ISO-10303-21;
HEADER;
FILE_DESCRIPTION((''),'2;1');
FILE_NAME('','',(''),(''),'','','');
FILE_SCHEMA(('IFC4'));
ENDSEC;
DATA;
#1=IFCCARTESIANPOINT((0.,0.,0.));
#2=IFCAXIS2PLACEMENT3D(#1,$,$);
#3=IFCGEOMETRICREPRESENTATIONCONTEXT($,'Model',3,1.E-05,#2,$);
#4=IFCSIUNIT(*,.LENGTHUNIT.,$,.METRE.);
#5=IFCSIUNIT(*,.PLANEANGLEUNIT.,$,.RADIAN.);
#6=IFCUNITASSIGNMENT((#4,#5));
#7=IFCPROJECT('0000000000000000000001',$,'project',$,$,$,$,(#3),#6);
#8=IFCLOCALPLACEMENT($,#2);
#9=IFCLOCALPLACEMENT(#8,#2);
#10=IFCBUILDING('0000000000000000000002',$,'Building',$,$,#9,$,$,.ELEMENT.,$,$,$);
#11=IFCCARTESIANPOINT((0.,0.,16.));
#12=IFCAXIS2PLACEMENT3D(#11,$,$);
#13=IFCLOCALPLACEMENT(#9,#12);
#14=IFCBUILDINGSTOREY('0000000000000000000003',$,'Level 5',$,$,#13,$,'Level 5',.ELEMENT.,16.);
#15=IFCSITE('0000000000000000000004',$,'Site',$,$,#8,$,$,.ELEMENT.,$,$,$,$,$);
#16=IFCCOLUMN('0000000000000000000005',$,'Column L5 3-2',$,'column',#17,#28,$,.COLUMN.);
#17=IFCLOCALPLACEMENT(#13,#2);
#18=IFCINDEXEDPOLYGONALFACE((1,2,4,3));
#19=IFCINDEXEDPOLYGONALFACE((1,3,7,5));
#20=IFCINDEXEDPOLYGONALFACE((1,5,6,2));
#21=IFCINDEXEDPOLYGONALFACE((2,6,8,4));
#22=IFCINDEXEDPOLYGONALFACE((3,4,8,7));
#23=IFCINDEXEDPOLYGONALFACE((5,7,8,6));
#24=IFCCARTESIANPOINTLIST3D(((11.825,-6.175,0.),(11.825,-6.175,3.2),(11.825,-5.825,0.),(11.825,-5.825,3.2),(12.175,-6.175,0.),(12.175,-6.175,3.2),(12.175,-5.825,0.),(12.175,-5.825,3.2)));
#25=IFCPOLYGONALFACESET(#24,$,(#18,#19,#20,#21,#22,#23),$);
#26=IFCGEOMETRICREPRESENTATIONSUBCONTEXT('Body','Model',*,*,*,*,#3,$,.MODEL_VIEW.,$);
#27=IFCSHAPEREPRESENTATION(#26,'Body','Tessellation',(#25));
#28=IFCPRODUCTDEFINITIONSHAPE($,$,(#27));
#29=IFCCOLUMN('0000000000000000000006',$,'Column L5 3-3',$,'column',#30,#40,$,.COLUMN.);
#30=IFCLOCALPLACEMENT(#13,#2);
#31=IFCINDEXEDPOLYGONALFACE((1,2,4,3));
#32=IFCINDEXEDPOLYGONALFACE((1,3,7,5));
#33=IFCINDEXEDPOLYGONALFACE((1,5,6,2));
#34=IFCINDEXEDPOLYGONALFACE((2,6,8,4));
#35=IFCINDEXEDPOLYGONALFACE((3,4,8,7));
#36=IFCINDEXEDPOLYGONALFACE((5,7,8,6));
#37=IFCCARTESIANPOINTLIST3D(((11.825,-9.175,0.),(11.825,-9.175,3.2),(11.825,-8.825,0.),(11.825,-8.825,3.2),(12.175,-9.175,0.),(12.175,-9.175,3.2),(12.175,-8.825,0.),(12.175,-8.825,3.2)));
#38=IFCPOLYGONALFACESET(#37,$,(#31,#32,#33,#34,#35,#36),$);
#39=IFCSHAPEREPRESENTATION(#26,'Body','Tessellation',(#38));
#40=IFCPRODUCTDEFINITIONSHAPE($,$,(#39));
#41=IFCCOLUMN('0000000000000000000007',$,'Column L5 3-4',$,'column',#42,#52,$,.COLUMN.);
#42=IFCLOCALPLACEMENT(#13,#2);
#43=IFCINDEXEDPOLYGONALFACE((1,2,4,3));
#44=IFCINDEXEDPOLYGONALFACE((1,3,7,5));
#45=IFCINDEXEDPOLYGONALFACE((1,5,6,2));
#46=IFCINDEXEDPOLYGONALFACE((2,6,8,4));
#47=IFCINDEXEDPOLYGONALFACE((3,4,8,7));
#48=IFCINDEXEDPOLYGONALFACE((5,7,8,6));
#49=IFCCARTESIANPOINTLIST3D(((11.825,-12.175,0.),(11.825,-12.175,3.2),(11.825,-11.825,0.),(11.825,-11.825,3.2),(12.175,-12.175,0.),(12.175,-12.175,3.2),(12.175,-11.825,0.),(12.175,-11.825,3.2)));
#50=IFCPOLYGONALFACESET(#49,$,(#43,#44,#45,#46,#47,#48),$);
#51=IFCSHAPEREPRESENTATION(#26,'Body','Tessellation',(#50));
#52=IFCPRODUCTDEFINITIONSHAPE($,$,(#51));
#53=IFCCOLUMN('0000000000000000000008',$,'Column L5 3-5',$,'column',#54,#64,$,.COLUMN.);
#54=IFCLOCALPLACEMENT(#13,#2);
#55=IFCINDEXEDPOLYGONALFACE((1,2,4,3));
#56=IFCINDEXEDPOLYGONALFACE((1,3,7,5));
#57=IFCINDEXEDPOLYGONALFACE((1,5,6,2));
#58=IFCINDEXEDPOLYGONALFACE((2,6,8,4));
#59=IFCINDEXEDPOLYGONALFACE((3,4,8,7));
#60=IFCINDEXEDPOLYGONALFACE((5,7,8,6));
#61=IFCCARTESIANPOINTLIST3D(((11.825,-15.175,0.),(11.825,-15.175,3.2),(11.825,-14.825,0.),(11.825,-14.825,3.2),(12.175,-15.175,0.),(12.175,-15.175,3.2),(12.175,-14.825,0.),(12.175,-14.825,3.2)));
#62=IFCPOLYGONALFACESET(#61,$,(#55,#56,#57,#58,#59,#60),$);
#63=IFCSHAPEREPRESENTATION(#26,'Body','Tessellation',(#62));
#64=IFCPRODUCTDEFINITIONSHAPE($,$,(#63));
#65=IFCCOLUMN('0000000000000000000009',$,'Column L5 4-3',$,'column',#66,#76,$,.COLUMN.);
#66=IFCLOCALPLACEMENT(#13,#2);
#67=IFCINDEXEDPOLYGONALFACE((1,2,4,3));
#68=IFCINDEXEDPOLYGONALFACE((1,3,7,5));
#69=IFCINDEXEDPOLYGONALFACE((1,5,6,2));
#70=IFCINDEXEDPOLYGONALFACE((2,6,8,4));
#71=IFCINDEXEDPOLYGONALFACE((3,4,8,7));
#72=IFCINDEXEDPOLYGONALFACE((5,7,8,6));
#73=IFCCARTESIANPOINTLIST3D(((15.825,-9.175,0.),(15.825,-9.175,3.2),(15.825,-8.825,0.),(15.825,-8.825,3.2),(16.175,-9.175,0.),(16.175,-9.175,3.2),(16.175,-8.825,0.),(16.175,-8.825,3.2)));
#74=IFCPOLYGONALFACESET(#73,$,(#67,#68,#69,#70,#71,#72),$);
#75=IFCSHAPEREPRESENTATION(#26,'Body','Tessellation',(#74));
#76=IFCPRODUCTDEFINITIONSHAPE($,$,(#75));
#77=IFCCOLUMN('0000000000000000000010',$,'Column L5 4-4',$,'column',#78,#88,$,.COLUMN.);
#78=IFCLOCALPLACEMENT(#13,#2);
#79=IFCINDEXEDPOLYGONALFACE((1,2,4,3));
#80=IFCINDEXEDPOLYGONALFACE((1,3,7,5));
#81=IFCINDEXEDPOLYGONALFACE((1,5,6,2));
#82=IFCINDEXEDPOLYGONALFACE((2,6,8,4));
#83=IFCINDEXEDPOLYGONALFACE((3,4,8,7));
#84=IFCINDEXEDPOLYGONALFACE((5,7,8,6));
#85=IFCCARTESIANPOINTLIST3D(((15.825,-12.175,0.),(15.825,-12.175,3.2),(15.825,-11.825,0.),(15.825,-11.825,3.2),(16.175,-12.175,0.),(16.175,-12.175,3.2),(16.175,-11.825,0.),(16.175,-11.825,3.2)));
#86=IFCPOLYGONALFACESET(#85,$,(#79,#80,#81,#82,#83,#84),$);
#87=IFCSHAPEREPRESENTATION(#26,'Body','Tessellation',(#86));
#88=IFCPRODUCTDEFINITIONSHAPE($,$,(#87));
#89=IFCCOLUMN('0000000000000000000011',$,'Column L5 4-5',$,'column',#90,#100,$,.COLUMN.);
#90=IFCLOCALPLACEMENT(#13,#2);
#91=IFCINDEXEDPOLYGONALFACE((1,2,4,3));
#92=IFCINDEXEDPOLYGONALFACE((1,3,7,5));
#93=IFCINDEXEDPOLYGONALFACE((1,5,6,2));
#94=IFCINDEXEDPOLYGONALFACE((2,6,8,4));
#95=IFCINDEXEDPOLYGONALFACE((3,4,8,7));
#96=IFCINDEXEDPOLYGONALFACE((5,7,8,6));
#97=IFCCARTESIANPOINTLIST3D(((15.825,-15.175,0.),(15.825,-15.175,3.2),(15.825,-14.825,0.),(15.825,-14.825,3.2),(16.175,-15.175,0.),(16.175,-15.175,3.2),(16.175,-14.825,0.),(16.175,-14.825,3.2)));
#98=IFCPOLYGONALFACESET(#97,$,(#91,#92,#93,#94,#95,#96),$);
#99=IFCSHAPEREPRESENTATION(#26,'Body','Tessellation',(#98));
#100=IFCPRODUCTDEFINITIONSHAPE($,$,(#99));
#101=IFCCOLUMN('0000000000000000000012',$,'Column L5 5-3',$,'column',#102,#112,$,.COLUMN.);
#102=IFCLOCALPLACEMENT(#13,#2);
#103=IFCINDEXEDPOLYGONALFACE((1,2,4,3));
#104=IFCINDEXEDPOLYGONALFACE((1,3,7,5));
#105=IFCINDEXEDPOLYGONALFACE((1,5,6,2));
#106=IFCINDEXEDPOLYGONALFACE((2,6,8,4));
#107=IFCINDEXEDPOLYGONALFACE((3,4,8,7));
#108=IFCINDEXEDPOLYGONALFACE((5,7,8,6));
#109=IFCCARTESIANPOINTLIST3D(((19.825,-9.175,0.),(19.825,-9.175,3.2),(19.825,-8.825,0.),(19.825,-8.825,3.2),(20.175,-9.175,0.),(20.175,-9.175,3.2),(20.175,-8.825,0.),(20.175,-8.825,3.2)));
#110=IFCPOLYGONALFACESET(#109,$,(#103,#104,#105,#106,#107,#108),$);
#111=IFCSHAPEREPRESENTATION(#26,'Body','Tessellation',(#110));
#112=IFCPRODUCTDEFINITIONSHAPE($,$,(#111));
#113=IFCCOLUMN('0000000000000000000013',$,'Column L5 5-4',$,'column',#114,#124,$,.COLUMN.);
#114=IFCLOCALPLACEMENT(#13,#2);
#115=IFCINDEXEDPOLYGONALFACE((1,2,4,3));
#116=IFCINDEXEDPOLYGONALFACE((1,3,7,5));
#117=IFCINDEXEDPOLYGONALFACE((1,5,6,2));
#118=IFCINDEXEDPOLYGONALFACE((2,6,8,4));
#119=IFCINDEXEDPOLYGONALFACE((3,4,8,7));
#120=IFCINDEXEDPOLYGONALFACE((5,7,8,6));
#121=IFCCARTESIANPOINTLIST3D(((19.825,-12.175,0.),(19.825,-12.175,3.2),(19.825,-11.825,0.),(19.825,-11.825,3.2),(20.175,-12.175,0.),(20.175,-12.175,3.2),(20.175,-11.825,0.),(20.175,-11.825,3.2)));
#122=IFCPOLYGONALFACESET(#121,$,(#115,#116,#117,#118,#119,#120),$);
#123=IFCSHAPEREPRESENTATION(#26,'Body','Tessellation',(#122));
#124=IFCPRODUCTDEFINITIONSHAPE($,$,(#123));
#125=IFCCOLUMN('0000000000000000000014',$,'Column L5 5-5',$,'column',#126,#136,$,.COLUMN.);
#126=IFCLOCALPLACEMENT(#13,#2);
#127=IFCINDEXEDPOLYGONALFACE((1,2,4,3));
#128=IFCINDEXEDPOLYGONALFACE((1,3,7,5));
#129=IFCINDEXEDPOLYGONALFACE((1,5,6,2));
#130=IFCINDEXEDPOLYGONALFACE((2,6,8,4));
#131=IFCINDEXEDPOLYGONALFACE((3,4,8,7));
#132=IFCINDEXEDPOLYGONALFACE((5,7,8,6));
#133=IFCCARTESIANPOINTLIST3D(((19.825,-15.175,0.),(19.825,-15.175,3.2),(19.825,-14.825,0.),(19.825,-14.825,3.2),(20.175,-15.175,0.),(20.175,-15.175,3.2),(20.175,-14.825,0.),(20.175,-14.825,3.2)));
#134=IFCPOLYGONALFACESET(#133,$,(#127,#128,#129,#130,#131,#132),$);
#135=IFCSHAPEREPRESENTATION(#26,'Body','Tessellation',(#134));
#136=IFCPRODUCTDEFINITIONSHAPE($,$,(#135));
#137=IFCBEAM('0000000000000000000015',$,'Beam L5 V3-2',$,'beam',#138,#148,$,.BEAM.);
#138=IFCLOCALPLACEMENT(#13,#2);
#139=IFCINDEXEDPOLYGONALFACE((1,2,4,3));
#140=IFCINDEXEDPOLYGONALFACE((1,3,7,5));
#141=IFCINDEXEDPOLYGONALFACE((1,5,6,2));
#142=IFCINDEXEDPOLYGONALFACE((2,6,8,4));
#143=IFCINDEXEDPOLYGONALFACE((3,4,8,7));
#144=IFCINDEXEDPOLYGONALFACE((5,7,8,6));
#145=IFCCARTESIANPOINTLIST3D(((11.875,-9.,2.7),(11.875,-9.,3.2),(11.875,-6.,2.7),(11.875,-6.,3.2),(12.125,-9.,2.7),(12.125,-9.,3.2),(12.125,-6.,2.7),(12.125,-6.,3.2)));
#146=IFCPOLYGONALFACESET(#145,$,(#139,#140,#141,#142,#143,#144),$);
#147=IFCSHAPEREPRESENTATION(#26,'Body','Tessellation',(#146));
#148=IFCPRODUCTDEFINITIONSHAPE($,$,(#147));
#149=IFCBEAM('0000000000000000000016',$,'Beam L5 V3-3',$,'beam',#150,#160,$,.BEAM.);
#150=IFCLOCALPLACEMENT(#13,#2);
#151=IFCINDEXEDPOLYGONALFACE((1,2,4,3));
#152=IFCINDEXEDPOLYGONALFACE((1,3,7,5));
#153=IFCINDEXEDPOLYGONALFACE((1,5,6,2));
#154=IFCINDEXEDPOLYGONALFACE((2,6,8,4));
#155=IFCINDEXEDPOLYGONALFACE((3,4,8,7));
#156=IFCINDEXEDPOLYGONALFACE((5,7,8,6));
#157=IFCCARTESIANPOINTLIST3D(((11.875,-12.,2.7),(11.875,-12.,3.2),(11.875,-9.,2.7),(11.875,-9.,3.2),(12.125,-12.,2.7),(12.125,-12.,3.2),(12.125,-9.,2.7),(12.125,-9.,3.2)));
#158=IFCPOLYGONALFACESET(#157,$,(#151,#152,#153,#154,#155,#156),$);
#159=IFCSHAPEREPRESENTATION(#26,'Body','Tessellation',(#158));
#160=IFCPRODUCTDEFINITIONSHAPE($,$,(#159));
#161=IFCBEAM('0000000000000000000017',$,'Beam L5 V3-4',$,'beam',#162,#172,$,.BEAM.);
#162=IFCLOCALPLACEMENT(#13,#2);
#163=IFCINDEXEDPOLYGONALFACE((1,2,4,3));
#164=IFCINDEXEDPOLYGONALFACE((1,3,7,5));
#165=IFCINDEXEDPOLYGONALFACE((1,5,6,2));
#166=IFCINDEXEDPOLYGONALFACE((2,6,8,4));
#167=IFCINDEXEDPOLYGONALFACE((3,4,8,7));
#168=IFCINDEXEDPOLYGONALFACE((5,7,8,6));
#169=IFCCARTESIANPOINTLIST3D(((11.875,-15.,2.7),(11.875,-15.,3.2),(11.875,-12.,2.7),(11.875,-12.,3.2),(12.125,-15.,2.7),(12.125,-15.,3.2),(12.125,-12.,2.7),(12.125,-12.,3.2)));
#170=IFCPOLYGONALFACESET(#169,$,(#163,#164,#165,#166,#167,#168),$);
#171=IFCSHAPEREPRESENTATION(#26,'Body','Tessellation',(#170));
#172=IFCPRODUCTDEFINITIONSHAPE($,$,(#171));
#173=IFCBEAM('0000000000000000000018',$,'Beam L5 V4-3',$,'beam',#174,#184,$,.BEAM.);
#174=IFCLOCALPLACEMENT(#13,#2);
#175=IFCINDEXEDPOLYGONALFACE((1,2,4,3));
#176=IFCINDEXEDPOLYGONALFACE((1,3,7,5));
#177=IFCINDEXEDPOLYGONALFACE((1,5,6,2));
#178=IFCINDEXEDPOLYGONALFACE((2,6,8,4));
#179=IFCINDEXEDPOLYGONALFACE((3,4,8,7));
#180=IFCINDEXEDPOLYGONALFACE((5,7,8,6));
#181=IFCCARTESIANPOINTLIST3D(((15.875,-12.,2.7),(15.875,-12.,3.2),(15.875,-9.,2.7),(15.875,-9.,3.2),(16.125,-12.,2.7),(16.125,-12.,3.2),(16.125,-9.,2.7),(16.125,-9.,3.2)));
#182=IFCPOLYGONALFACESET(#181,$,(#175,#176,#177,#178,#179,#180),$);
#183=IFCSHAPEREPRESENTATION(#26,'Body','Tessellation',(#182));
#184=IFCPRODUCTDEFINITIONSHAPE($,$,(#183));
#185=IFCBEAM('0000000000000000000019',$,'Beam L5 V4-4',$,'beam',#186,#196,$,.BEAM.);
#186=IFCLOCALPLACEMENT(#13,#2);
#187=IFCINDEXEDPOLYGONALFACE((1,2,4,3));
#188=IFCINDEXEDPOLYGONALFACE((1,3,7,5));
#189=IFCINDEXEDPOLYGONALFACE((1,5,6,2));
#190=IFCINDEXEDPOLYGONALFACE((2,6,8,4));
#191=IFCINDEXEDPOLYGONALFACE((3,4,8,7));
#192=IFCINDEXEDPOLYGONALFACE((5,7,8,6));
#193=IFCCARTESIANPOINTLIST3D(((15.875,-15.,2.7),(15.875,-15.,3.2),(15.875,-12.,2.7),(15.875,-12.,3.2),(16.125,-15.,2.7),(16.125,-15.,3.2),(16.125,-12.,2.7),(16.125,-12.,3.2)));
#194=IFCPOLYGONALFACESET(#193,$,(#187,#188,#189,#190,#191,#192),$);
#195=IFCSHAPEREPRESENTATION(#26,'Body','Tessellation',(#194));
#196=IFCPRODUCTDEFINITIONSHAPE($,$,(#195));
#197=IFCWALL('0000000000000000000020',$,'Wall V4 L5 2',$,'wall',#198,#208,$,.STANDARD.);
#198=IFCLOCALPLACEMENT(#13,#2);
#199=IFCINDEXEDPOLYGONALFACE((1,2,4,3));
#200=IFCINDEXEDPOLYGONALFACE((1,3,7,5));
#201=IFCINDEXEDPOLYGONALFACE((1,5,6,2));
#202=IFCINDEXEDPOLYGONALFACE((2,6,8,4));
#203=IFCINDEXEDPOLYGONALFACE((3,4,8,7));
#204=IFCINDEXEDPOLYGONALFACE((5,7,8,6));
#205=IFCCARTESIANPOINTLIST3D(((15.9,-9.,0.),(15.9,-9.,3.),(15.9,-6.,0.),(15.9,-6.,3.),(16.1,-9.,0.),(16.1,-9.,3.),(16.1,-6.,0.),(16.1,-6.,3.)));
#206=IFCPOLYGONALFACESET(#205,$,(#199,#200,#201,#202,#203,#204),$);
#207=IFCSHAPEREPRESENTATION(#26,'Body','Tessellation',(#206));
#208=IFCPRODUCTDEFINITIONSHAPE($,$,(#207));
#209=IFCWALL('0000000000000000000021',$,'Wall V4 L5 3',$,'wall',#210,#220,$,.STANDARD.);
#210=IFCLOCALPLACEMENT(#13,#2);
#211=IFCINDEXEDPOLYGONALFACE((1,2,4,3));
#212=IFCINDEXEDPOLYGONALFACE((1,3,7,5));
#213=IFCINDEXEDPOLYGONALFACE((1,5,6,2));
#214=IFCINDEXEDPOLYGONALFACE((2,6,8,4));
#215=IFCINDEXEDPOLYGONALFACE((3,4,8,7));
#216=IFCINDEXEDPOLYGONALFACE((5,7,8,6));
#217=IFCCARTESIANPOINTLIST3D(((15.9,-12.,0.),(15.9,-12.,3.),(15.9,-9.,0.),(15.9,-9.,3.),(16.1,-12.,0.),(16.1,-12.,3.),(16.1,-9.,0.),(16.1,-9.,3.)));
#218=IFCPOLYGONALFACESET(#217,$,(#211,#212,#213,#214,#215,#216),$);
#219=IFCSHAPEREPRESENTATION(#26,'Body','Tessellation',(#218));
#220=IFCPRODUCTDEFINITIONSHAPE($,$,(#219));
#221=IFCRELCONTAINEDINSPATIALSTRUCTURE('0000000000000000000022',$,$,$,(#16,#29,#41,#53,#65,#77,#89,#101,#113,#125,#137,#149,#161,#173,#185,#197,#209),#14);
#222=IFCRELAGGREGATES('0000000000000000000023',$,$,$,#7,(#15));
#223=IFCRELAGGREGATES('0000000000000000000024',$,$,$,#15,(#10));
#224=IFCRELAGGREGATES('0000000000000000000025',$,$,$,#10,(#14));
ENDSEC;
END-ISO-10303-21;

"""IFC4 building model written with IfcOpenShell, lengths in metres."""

from ifc_helpers import new_model, si_unit, frame, frame_2d, origin, origin_2d, place, context, subcontext, project, spatial, rectangle, extrude, element, save


model = new_model("IFC4")

# Units and contexts
model_context = context("Model", 3, precision=1e-05, world=origin())
body_context = subcontext(model_context, "Body", "Model", "MODEL_VIEW")
ifc_project = project(units=[si_unit("LENGTHUNIT", "METRE"), si_unit("PLANEANGLEUNIT", "RADIAN")], contexts=[model_context])

# Site, building, storey
site_placement = place(None, origin())
site = spatial("IfcSite", under=ifc_project, at=site_placement, Name="Site", CompositionType="ELEMENT")
building_placement = place(site_placement, origin())
building = spatial("IfcBuilding", under=site, at=building_placement, Name="Building", CompositionType="ELEMENT")
storey_placement = place(building_placement, frame((0.0, 0.0, 16.0)))
storey = spatial("IfcBuildingStorey", under=building, at=storey_placement, Name="Level 5", LongName="Level 5", CompositionType="ELEMENT", Elevation=16.0)

# Columns
for number, where, name in (
    (1, (12.0, -6.0, 0.0), "Column L5 3-2"),
    (2, (12.0, -9.0, 0.0), "Column L5 3-3"),
    (3, (12.0, -12.0, 0.0), "Column L5 3-4"),
    (4, (12.0, -15.0, 0.0), "Column L5 3-5"),
    (5, (16.0, -9.0, 0.0), "Column L5 4-3"),
    (6, (16.0, -12.0, 0.0), "Column L5 4-4"),
    (7, (16.0, -15.0, 0.0), "Column L5 4-5"),
    (8, (20.0, -9.0, 0.0), "Column L5 5-3"),
    (9, (20.0, -12.0, 0.0), "Column L5 5-4"),
    (10, (20.0, -15.0, 0.0), "Column L5 5-5"),
):
    element("IfcColumn", number, at=place(storey_placement, frame(where)), inside=storey, Name=name, ObjectType="column", PredefinedType="COLUMN", context=body_context, shape_type="SweptSolid", body=[
        extrude(rectangle(XDim=0.35, YDim=0.35, at=origin_2d()), origin(), (0.0, 0.0, 1.0), 3.2),
    ])

# Beams
for number, where, z_axis, x_axis, name in (
    (11, (12.0, -6.0, 2.95), (0.0, -1.0, 0.0), (0.0, 0.0, 1.0), "Beam L5 V3-2"),
    (12, (12.0, -9.0, 2.95), (0.0, -1.0, 0.0), (0.0, 0.0, 1.0), "Beam L5 V3-3"),
    (13, (12.0, -12.0, 2.95), (0.0, -1.0, 0.0), (0.0, 0.0, 1.0), "Beam L5 V3-4"),
    (14, (16.0, -9.0, 2.95), (0.0, -1.0, 0.0), (0.0, 0.0, 1.0), "Beam L5 V4-3"),
    (15, (16.0, -12.0, 2.95), (0.0, -1.0, 0.0), (0.0, 0.0, 1.0), "Beam L5 V4-4"),
):
    element("IfcBeam", number, at=place(storey_placement, frame(where, z_axis=z_axis, x_axis=x_axis)), inside=storey, Name=name, ObjectType="beam", PredefinedType="BEAM", context=body_context, shape_type="SweptSolid", body=[
        extrude(rectangle(XDim=0.5, YDim=0.25, at=origin_2d()), origin(), (0.0, 0.0, 1.0), 3.0),
    ])

# Walls
for number, where, z_axis, x_axis, name in (
    (16, (16.0, -6.0, 0.0), (0.0, 0.0, 1.0), (0.0, -1.0, 0.0), "Wall V4 L5 2"),
    (17, (16.0, -9.0, 0.0), (0.0, 0.0, 1.0), (0.0, -1.0, 0.0), "Wall V4 L5 3"),
):
    element("IfcWall", number, at=place(storey_placement, frame(where, z_axis=z_axis, x_axis=x_axis)), inside=storey, Name=name, ObjectType="wall", PredefinedType="STANDARD", context=body_context, shape_type="SweptSolid", body=[
        extrude(rectangle(XDim=3.0, YDim=0.2, at=frame_2d((1.5, 0.0))), origin(), (0.0, 0.0, 1.0), 3.0),
    ])

save(model, "model.ifc")
